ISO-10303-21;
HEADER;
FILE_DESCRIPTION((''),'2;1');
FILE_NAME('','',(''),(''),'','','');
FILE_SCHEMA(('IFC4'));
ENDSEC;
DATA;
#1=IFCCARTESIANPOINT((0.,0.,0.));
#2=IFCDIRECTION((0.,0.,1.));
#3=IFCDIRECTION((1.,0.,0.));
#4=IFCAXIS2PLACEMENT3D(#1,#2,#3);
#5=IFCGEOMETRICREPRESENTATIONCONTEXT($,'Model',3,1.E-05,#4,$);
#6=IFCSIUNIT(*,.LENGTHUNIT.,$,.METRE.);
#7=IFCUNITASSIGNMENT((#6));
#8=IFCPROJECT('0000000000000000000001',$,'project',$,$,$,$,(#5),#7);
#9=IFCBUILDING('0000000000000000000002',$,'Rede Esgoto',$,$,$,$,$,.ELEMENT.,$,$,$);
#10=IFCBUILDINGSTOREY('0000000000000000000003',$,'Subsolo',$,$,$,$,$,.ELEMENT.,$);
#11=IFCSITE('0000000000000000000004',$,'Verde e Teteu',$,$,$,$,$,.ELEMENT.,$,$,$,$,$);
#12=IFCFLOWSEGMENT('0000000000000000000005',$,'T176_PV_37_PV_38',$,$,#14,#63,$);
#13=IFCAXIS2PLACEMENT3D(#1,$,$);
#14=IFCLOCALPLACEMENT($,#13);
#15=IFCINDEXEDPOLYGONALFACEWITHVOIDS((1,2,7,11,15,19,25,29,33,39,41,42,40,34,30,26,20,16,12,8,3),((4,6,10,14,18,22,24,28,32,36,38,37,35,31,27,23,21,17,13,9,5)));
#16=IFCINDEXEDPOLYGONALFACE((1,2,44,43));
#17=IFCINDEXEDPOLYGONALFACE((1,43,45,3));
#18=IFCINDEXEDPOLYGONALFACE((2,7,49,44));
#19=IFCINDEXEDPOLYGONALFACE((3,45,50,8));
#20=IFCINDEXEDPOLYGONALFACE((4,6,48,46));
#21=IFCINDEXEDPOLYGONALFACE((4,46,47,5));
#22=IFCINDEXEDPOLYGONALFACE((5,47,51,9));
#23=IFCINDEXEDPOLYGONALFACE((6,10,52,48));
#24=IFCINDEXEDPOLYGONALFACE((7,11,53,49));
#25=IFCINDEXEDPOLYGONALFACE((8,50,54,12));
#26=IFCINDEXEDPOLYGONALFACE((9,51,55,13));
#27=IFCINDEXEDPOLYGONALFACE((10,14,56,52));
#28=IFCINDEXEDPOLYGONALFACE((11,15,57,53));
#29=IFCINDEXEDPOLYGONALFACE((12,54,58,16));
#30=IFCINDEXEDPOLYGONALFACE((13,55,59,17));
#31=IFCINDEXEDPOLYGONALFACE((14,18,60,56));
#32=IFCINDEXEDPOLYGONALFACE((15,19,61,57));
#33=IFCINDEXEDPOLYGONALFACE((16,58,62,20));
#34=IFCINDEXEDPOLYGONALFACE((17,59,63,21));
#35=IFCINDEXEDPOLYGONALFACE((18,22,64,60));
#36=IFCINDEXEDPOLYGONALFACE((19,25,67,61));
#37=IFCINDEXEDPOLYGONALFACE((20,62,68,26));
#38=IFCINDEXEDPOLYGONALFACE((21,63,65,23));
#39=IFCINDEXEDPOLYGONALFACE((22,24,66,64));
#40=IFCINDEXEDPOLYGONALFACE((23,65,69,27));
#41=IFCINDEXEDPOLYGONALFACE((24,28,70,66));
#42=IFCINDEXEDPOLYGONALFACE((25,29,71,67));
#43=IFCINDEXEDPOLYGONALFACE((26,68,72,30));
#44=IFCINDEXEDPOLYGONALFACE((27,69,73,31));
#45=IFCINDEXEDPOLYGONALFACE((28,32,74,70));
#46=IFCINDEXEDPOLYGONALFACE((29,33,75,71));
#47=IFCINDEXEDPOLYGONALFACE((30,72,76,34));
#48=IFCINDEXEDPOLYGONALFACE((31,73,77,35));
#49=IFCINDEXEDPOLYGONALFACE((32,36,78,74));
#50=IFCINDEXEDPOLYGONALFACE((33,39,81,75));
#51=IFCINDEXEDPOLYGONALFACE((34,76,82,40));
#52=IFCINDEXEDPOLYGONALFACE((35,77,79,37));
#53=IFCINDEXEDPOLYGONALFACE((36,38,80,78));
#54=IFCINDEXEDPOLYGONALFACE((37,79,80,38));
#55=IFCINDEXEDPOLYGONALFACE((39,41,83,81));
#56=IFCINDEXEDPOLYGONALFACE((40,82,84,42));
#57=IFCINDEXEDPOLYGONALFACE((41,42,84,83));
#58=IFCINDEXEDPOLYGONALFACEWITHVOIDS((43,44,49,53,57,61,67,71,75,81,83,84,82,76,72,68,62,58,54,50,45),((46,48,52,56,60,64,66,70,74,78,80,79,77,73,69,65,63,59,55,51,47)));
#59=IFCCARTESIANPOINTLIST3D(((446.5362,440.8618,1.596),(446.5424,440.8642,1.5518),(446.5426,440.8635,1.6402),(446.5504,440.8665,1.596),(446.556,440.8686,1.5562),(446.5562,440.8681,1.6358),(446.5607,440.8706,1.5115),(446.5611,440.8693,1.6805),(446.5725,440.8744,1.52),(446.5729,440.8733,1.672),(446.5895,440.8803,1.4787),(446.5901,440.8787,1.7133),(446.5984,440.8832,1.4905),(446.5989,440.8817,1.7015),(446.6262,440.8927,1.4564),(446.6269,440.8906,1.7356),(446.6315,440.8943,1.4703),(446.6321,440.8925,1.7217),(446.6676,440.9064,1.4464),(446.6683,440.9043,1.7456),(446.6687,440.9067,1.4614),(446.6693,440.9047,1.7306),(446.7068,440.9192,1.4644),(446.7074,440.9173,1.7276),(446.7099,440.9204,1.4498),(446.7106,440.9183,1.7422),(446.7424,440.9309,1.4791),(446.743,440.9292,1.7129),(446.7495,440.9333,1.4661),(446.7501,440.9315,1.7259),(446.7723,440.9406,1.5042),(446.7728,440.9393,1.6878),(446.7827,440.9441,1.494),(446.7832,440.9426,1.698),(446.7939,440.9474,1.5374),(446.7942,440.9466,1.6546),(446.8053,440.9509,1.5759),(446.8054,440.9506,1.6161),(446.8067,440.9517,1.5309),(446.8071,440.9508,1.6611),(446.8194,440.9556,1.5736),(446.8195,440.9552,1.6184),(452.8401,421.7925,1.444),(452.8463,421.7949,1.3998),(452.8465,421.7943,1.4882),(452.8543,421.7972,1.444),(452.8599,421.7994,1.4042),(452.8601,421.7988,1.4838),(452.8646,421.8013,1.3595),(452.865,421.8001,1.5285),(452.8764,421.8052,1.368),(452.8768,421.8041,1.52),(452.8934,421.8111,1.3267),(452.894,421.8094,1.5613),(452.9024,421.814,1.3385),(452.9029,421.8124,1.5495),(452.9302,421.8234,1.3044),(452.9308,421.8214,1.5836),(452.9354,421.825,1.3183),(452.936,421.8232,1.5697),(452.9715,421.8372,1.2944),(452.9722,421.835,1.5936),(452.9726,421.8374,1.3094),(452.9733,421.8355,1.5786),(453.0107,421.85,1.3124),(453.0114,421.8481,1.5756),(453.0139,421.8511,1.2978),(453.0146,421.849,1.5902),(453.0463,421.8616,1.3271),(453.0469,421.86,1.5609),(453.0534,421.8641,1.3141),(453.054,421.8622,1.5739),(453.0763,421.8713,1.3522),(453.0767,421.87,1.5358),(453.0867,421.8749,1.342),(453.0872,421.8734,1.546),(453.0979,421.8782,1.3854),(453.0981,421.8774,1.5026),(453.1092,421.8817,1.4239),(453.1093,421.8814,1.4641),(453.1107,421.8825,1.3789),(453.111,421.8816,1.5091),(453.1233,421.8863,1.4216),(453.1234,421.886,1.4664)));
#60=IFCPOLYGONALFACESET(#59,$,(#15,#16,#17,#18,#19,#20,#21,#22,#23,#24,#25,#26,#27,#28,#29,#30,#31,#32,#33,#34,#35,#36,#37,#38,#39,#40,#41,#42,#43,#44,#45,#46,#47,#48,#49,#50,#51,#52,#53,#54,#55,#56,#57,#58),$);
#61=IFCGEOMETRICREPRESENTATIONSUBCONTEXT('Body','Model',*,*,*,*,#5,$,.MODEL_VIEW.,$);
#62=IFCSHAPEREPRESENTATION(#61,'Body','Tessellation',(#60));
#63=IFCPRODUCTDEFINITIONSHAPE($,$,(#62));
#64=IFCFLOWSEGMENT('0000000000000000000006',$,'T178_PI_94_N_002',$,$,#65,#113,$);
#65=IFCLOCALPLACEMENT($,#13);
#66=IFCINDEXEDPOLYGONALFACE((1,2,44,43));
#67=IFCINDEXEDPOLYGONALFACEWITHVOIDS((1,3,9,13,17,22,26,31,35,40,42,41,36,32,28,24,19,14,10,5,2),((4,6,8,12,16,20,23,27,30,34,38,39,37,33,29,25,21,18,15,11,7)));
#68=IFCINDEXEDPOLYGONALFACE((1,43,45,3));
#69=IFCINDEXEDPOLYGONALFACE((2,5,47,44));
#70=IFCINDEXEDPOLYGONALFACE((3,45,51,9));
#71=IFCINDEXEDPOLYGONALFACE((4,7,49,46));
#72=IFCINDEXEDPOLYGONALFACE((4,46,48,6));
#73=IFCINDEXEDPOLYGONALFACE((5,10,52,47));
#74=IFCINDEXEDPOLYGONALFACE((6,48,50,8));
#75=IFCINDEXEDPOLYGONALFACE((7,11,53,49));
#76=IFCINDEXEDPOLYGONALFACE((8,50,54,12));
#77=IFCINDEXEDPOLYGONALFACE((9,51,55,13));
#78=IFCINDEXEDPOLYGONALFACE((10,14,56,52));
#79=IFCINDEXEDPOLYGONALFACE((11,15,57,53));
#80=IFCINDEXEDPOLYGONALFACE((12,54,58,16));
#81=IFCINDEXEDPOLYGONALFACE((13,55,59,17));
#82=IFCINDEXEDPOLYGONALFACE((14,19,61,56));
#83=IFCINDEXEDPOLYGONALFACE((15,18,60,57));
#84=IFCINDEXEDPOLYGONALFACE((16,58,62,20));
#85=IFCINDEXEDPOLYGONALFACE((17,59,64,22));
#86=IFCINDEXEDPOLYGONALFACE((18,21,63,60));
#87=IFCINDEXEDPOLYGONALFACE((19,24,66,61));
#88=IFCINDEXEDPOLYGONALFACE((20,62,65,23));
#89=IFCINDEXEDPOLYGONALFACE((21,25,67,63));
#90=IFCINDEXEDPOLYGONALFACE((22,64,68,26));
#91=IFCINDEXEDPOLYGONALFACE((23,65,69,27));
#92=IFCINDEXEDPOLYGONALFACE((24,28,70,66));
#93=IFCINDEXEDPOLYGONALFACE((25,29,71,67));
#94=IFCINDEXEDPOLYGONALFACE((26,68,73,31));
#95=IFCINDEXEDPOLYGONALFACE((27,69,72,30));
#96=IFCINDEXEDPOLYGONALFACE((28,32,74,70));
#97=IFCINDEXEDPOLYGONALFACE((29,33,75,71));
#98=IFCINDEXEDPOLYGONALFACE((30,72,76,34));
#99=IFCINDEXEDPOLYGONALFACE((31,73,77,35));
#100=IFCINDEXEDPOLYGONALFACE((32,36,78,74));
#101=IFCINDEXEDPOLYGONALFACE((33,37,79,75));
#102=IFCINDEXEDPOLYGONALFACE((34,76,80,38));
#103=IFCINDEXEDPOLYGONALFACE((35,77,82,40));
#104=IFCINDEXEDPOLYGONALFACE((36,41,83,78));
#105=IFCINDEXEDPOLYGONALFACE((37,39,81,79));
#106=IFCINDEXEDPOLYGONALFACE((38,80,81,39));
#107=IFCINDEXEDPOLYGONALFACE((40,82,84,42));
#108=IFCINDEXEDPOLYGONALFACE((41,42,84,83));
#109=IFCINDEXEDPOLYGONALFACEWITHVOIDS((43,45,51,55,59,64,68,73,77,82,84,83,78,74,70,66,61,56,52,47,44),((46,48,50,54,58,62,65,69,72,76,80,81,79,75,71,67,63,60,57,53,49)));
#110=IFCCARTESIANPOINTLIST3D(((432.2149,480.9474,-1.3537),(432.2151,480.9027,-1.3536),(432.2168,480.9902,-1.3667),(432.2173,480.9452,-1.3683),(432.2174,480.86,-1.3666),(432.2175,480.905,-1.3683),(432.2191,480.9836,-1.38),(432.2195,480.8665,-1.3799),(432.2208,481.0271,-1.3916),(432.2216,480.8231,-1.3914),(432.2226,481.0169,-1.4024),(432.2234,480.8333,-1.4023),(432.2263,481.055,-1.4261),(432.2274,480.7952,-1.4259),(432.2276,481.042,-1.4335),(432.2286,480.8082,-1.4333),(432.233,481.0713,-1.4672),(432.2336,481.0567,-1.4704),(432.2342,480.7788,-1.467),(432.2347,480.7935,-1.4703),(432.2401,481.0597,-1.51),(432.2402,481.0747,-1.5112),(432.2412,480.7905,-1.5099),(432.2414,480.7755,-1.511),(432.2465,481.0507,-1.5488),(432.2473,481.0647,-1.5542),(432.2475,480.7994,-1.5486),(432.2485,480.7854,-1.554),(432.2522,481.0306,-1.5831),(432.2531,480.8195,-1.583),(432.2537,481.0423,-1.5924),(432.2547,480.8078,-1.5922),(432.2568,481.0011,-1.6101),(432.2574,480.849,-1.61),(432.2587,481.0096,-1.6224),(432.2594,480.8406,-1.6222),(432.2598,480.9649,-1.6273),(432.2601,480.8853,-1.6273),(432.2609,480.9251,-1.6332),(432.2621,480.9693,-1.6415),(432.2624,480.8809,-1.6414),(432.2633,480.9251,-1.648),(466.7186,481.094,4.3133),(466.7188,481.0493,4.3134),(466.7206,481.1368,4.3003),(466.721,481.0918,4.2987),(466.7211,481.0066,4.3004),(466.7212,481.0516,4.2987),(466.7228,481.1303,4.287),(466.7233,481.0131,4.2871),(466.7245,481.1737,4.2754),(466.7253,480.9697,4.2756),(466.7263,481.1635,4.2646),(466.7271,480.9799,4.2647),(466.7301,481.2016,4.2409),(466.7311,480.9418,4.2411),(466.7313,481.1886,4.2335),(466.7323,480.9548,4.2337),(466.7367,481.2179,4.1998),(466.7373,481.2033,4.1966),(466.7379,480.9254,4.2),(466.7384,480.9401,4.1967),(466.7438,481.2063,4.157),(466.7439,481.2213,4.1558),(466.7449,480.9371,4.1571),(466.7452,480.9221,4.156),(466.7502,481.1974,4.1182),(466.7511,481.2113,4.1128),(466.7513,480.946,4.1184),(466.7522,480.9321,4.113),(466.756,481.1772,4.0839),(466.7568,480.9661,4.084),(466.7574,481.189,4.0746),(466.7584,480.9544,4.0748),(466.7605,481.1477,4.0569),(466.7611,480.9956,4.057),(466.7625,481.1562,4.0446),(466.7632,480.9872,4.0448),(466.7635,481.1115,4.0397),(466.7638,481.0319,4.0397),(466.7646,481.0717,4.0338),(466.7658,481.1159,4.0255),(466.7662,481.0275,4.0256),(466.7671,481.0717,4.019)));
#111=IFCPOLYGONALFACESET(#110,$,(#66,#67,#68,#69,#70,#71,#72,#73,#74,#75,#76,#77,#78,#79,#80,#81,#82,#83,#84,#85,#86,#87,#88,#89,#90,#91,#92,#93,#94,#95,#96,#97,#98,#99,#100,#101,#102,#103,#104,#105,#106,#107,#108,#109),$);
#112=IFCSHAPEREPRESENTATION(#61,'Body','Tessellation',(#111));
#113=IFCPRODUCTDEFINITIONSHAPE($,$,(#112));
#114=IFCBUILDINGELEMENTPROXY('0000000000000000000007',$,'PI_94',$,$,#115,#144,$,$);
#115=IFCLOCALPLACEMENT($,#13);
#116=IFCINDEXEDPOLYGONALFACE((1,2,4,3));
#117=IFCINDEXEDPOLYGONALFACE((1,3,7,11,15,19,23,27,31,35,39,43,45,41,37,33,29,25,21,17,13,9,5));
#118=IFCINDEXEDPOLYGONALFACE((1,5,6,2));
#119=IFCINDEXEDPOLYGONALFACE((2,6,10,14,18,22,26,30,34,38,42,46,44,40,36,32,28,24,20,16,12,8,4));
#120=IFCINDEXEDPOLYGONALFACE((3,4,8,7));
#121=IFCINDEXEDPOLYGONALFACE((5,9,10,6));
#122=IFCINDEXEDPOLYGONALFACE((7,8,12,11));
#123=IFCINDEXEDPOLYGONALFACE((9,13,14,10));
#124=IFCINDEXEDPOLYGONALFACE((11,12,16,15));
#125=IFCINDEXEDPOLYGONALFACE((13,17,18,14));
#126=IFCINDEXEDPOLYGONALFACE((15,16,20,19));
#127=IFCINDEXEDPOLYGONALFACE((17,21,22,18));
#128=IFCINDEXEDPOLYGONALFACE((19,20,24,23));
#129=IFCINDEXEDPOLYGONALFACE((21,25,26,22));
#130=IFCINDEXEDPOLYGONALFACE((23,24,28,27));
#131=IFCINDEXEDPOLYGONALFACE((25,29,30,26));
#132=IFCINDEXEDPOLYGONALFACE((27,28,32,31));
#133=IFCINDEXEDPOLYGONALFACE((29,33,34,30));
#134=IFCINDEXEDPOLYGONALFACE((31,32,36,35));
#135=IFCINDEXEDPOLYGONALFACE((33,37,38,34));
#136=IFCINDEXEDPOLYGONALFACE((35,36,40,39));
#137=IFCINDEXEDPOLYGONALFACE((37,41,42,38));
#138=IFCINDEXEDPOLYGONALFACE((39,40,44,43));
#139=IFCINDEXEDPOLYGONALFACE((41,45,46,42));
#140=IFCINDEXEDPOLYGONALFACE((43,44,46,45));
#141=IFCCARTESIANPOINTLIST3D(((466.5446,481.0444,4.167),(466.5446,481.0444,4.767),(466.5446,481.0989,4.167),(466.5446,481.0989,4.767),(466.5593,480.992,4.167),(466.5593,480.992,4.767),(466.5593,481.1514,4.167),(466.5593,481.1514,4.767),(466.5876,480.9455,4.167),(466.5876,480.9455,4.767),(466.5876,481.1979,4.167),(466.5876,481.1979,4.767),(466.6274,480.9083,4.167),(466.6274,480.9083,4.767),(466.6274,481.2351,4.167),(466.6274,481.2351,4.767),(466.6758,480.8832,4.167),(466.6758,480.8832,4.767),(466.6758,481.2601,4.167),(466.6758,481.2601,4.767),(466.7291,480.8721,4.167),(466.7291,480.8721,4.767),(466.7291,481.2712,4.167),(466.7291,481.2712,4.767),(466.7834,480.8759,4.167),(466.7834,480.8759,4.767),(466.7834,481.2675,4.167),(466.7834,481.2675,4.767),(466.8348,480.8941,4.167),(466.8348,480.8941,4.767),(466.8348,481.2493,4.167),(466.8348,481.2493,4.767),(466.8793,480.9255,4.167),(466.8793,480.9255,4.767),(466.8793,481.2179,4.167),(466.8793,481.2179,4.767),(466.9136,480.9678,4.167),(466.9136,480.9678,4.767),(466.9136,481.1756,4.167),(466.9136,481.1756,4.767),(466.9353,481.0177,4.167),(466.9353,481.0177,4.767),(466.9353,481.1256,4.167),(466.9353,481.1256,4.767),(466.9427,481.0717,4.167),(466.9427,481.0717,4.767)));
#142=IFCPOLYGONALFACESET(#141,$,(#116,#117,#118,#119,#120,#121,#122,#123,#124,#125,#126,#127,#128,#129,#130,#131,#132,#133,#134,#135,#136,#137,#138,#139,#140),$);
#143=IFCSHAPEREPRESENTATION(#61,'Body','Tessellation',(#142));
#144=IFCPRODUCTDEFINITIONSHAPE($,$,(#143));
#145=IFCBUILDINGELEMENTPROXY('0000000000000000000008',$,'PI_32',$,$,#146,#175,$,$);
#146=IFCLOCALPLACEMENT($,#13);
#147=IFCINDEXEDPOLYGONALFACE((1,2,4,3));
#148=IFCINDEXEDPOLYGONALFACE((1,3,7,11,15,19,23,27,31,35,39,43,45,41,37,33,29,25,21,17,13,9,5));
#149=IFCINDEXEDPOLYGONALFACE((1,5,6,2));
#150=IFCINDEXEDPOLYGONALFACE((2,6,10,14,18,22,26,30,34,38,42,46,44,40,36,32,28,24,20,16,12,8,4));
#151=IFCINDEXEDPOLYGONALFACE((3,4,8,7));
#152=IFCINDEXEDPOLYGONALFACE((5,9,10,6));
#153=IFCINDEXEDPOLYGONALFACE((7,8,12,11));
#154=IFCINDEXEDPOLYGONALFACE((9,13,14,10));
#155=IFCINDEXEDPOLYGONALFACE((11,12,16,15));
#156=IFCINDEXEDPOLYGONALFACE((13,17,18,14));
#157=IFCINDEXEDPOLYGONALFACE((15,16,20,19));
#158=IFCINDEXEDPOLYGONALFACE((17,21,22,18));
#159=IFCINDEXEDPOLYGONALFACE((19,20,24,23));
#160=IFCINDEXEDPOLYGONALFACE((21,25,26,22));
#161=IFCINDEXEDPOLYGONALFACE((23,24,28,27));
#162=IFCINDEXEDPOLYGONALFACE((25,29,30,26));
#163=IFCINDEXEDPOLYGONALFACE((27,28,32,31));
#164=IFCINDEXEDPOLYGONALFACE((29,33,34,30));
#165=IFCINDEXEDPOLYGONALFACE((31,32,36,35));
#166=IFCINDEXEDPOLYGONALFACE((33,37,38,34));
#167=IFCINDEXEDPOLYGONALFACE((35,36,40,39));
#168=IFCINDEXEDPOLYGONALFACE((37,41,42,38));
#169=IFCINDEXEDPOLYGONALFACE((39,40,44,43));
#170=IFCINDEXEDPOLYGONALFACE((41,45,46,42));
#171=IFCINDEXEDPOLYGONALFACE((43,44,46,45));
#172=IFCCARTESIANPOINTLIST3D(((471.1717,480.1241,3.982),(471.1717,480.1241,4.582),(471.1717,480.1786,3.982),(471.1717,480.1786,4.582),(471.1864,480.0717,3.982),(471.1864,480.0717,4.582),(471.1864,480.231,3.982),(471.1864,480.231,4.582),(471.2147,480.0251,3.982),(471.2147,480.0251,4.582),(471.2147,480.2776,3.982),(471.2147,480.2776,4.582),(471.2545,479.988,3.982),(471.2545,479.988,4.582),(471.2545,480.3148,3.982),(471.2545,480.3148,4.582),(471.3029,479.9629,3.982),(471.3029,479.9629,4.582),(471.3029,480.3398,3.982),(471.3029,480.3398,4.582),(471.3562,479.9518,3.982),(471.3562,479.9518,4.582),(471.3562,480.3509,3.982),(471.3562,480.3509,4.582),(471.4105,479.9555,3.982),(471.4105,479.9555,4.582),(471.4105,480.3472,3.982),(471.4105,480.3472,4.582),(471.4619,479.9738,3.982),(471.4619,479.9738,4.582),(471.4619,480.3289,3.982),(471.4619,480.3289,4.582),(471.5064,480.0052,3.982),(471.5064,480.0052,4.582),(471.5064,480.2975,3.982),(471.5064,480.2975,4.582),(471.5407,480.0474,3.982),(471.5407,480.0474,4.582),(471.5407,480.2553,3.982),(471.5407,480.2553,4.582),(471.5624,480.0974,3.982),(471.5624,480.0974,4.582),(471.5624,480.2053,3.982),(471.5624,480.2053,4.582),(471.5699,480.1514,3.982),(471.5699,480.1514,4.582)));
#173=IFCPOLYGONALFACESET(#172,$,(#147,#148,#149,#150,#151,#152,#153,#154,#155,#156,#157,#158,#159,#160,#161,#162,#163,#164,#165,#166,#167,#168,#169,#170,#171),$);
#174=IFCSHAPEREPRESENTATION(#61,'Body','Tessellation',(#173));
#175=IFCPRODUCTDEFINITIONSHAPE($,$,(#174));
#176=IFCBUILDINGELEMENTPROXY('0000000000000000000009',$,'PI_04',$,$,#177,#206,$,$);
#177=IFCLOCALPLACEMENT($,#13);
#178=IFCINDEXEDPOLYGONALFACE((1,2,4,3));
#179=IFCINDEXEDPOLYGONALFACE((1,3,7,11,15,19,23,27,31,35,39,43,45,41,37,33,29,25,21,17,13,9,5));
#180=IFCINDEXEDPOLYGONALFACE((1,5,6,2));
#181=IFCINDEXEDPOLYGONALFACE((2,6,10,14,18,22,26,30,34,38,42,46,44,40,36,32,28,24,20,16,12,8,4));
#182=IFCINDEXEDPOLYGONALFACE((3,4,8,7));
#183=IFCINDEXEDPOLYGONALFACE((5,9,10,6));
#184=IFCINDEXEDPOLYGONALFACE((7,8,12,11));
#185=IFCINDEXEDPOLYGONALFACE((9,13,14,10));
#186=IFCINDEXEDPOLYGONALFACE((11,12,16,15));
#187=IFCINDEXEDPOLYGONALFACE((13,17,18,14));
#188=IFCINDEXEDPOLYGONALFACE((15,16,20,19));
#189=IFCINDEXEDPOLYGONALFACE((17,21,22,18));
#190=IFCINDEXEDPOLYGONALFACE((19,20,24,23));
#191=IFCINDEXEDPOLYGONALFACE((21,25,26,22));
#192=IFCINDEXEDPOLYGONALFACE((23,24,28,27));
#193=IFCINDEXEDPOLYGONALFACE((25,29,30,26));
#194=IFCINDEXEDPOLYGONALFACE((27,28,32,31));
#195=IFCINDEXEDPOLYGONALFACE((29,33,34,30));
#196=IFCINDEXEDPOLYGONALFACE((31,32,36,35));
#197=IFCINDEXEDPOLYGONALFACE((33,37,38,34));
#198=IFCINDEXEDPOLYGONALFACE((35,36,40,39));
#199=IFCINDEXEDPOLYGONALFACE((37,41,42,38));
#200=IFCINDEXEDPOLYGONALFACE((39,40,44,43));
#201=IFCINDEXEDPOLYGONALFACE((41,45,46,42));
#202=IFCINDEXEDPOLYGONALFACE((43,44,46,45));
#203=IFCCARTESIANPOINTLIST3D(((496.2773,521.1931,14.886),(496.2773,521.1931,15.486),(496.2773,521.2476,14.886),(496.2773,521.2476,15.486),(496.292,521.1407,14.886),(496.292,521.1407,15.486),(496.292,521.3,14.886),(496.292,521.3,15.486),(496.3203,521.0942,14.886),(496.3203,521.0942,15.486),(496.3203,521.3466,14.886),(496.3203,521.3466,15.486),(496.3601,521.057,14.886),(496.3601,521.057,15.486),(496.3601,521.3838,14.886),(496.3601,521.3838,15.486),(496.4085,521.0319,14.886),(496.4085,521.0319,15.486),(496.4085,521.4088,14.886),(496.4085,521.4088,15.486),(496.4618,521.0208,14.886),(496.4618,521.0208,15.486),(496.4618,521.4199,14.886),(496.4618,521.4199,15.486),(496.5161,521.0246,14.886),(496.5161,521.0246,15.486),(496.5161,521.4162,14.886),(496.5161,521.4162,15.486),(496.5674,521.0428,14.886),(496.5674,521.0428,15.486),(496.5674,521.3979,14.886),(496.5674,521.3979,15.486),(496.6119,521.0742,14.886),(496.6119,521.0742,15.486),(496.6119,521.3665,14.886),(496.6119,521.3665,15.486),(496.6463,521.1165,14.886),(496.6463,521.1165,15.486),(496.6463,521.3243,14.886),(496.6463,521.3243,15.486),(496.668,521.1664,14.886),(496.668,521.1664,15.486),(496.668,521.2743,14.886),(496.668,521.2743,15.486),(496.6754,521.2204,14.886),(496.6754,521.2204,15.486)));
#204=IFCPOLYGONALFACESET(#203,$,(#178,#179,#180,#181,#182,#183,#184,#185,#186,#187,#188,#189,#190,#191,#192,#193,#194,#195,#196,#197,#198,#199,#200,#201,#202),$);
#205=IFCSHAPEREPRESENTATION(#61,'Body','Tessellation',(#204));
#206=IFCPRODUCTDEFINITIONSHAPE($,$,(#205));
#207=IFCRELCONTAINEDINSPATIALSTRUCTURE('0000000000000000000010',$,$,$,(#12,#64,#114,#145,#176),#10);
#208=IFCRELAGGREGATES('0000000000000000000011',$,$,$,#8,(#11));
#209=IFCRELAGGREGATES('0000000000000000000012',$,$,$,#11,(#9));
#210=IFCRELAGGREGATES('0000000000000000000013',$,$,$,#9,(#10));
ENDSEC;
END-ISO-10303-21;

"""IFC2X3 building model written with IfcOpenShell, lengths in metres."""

from ifc_helpers import new_model, entity, si_unit, frame, origin_with_axes, origin_2d, place, context, subcontext, project, spatial, circle, extrude, element, save


model = new_model("IFC2X3")

# Units and contexts
model_context = context("Model", 3, precision=1e-05, world=origin_with_axes())
body_context = subcontext(model_context, "Body", "Model", "MODEL_VIEW")
ifc_project = project(units=[si_unit("LENGTHUNIT", "METRE")], contexts=[model_context])

# Site, building, storey
site = spatial("IfcSite", under=ifc_project, Name="Verde e Teteu", CompositionType="ELEMENT")
building = spatial("IfcBuilding", under=site, Name="Rede Esgoto", CompositionType="ELEMENT")
storey = spatial("IfcBuildingStorey", under=building, Name="Subsolo", CompositionType="ELEMENT")

# Flow segments
flow_segment_1_placement = place(None, frame((446.6786, 440.9089, 1.596), z_axis=(0.0, 0.0, 1.0), x_axis=(1.0, 0.0, 0.0)))
element("IfcFlowSegment", 1, at=flow_segment_1_placement, inside=storey, Name="T176_PV_37_PV_38", context=body_context, shape_type="SweptSolid", body=[
    entity("IfcSweptDiskSolid", entity("IfcPolyline", [entity("IfcCartesianPoint", [0.0, 0.0, 0.0]), entity("IfcCartesianPoint", [6.3039, -19.0692, -0.152])]), 0.15, 0.135),
])
flow_segment_2_placement = place(None, frame((466.7427, 481.0717, 4.167), z_axis=(0.0, 0.0, 1.0), x_axis=(1.0, 0.0, 0.0)))
element("IfcFlowSegment", 2, at=flow_segment_2_placement, inside=storey, Name="T178_PI_94_N_002", context=body_context, shape_type="SweptSolid", body=[
    entity("IfcSweptDiskSolid", entity("IfcPolyline", [entity("IfcCartesianPoint", [0.0, 0.0, 0.0]), entity("IfcCartesianPoint", [-34.5037, -0.1466, -5.667])]), 0.15, 0.135),
])

# Building element proxies
proxy_1_placement = place(None, frame((466.7427, 481.0717, 4.167), z_axis=(0.0, 0.0, 1.0), x_axis=(1.0, 0.0, 0.0)))
element("IfcBuildingElementProxy", 3, at=proxy_1_placement, inside=storey, Name="PI_94", context=body_context, shape_type="SweptSolid", body=[
    extrude(circle(Radius=0.2, at=origin_2d()), origin_with_axes(), (0.0, 0.0, 1.0), 0.6),
])
proxy_2_placement = place(None, frame((471.3699, 480.1514, 3.982), z_axis=(0.0, 0.0, 1.0), x_axis=(1.0, 0.0, 0.0)))
element("IfcBuildingElementProxy", 4, at=proxy_2_placement, inside=storey, Name="PI_32", context=body_context, shape_type="SweptSolid", body=[
    extrude(circle(Radius=0.2, at=origin_2d()), origin_with_axes(), (0.0, 0.0, 1.0), 0.6),
])
proxy_3_placement = place(None, frame((496.4754, 521.2204, 14.886), z_axis=(0.0, 0.0, 1.0), x_axis=(1.0, 0.0, 0.0)))
element("IfcBuildingElementProxy", 5, at=proxy_3_placement, inside=storey, Name="PI_04", context=body_context, shape_type="SweptSolid", body=[
    extrude(circle(Radius=0.2, at=origin_2d()), origin_with_axes(), (0.0, 0.0, 1.0), 0.6),
])

save(model, "model.ifc")
